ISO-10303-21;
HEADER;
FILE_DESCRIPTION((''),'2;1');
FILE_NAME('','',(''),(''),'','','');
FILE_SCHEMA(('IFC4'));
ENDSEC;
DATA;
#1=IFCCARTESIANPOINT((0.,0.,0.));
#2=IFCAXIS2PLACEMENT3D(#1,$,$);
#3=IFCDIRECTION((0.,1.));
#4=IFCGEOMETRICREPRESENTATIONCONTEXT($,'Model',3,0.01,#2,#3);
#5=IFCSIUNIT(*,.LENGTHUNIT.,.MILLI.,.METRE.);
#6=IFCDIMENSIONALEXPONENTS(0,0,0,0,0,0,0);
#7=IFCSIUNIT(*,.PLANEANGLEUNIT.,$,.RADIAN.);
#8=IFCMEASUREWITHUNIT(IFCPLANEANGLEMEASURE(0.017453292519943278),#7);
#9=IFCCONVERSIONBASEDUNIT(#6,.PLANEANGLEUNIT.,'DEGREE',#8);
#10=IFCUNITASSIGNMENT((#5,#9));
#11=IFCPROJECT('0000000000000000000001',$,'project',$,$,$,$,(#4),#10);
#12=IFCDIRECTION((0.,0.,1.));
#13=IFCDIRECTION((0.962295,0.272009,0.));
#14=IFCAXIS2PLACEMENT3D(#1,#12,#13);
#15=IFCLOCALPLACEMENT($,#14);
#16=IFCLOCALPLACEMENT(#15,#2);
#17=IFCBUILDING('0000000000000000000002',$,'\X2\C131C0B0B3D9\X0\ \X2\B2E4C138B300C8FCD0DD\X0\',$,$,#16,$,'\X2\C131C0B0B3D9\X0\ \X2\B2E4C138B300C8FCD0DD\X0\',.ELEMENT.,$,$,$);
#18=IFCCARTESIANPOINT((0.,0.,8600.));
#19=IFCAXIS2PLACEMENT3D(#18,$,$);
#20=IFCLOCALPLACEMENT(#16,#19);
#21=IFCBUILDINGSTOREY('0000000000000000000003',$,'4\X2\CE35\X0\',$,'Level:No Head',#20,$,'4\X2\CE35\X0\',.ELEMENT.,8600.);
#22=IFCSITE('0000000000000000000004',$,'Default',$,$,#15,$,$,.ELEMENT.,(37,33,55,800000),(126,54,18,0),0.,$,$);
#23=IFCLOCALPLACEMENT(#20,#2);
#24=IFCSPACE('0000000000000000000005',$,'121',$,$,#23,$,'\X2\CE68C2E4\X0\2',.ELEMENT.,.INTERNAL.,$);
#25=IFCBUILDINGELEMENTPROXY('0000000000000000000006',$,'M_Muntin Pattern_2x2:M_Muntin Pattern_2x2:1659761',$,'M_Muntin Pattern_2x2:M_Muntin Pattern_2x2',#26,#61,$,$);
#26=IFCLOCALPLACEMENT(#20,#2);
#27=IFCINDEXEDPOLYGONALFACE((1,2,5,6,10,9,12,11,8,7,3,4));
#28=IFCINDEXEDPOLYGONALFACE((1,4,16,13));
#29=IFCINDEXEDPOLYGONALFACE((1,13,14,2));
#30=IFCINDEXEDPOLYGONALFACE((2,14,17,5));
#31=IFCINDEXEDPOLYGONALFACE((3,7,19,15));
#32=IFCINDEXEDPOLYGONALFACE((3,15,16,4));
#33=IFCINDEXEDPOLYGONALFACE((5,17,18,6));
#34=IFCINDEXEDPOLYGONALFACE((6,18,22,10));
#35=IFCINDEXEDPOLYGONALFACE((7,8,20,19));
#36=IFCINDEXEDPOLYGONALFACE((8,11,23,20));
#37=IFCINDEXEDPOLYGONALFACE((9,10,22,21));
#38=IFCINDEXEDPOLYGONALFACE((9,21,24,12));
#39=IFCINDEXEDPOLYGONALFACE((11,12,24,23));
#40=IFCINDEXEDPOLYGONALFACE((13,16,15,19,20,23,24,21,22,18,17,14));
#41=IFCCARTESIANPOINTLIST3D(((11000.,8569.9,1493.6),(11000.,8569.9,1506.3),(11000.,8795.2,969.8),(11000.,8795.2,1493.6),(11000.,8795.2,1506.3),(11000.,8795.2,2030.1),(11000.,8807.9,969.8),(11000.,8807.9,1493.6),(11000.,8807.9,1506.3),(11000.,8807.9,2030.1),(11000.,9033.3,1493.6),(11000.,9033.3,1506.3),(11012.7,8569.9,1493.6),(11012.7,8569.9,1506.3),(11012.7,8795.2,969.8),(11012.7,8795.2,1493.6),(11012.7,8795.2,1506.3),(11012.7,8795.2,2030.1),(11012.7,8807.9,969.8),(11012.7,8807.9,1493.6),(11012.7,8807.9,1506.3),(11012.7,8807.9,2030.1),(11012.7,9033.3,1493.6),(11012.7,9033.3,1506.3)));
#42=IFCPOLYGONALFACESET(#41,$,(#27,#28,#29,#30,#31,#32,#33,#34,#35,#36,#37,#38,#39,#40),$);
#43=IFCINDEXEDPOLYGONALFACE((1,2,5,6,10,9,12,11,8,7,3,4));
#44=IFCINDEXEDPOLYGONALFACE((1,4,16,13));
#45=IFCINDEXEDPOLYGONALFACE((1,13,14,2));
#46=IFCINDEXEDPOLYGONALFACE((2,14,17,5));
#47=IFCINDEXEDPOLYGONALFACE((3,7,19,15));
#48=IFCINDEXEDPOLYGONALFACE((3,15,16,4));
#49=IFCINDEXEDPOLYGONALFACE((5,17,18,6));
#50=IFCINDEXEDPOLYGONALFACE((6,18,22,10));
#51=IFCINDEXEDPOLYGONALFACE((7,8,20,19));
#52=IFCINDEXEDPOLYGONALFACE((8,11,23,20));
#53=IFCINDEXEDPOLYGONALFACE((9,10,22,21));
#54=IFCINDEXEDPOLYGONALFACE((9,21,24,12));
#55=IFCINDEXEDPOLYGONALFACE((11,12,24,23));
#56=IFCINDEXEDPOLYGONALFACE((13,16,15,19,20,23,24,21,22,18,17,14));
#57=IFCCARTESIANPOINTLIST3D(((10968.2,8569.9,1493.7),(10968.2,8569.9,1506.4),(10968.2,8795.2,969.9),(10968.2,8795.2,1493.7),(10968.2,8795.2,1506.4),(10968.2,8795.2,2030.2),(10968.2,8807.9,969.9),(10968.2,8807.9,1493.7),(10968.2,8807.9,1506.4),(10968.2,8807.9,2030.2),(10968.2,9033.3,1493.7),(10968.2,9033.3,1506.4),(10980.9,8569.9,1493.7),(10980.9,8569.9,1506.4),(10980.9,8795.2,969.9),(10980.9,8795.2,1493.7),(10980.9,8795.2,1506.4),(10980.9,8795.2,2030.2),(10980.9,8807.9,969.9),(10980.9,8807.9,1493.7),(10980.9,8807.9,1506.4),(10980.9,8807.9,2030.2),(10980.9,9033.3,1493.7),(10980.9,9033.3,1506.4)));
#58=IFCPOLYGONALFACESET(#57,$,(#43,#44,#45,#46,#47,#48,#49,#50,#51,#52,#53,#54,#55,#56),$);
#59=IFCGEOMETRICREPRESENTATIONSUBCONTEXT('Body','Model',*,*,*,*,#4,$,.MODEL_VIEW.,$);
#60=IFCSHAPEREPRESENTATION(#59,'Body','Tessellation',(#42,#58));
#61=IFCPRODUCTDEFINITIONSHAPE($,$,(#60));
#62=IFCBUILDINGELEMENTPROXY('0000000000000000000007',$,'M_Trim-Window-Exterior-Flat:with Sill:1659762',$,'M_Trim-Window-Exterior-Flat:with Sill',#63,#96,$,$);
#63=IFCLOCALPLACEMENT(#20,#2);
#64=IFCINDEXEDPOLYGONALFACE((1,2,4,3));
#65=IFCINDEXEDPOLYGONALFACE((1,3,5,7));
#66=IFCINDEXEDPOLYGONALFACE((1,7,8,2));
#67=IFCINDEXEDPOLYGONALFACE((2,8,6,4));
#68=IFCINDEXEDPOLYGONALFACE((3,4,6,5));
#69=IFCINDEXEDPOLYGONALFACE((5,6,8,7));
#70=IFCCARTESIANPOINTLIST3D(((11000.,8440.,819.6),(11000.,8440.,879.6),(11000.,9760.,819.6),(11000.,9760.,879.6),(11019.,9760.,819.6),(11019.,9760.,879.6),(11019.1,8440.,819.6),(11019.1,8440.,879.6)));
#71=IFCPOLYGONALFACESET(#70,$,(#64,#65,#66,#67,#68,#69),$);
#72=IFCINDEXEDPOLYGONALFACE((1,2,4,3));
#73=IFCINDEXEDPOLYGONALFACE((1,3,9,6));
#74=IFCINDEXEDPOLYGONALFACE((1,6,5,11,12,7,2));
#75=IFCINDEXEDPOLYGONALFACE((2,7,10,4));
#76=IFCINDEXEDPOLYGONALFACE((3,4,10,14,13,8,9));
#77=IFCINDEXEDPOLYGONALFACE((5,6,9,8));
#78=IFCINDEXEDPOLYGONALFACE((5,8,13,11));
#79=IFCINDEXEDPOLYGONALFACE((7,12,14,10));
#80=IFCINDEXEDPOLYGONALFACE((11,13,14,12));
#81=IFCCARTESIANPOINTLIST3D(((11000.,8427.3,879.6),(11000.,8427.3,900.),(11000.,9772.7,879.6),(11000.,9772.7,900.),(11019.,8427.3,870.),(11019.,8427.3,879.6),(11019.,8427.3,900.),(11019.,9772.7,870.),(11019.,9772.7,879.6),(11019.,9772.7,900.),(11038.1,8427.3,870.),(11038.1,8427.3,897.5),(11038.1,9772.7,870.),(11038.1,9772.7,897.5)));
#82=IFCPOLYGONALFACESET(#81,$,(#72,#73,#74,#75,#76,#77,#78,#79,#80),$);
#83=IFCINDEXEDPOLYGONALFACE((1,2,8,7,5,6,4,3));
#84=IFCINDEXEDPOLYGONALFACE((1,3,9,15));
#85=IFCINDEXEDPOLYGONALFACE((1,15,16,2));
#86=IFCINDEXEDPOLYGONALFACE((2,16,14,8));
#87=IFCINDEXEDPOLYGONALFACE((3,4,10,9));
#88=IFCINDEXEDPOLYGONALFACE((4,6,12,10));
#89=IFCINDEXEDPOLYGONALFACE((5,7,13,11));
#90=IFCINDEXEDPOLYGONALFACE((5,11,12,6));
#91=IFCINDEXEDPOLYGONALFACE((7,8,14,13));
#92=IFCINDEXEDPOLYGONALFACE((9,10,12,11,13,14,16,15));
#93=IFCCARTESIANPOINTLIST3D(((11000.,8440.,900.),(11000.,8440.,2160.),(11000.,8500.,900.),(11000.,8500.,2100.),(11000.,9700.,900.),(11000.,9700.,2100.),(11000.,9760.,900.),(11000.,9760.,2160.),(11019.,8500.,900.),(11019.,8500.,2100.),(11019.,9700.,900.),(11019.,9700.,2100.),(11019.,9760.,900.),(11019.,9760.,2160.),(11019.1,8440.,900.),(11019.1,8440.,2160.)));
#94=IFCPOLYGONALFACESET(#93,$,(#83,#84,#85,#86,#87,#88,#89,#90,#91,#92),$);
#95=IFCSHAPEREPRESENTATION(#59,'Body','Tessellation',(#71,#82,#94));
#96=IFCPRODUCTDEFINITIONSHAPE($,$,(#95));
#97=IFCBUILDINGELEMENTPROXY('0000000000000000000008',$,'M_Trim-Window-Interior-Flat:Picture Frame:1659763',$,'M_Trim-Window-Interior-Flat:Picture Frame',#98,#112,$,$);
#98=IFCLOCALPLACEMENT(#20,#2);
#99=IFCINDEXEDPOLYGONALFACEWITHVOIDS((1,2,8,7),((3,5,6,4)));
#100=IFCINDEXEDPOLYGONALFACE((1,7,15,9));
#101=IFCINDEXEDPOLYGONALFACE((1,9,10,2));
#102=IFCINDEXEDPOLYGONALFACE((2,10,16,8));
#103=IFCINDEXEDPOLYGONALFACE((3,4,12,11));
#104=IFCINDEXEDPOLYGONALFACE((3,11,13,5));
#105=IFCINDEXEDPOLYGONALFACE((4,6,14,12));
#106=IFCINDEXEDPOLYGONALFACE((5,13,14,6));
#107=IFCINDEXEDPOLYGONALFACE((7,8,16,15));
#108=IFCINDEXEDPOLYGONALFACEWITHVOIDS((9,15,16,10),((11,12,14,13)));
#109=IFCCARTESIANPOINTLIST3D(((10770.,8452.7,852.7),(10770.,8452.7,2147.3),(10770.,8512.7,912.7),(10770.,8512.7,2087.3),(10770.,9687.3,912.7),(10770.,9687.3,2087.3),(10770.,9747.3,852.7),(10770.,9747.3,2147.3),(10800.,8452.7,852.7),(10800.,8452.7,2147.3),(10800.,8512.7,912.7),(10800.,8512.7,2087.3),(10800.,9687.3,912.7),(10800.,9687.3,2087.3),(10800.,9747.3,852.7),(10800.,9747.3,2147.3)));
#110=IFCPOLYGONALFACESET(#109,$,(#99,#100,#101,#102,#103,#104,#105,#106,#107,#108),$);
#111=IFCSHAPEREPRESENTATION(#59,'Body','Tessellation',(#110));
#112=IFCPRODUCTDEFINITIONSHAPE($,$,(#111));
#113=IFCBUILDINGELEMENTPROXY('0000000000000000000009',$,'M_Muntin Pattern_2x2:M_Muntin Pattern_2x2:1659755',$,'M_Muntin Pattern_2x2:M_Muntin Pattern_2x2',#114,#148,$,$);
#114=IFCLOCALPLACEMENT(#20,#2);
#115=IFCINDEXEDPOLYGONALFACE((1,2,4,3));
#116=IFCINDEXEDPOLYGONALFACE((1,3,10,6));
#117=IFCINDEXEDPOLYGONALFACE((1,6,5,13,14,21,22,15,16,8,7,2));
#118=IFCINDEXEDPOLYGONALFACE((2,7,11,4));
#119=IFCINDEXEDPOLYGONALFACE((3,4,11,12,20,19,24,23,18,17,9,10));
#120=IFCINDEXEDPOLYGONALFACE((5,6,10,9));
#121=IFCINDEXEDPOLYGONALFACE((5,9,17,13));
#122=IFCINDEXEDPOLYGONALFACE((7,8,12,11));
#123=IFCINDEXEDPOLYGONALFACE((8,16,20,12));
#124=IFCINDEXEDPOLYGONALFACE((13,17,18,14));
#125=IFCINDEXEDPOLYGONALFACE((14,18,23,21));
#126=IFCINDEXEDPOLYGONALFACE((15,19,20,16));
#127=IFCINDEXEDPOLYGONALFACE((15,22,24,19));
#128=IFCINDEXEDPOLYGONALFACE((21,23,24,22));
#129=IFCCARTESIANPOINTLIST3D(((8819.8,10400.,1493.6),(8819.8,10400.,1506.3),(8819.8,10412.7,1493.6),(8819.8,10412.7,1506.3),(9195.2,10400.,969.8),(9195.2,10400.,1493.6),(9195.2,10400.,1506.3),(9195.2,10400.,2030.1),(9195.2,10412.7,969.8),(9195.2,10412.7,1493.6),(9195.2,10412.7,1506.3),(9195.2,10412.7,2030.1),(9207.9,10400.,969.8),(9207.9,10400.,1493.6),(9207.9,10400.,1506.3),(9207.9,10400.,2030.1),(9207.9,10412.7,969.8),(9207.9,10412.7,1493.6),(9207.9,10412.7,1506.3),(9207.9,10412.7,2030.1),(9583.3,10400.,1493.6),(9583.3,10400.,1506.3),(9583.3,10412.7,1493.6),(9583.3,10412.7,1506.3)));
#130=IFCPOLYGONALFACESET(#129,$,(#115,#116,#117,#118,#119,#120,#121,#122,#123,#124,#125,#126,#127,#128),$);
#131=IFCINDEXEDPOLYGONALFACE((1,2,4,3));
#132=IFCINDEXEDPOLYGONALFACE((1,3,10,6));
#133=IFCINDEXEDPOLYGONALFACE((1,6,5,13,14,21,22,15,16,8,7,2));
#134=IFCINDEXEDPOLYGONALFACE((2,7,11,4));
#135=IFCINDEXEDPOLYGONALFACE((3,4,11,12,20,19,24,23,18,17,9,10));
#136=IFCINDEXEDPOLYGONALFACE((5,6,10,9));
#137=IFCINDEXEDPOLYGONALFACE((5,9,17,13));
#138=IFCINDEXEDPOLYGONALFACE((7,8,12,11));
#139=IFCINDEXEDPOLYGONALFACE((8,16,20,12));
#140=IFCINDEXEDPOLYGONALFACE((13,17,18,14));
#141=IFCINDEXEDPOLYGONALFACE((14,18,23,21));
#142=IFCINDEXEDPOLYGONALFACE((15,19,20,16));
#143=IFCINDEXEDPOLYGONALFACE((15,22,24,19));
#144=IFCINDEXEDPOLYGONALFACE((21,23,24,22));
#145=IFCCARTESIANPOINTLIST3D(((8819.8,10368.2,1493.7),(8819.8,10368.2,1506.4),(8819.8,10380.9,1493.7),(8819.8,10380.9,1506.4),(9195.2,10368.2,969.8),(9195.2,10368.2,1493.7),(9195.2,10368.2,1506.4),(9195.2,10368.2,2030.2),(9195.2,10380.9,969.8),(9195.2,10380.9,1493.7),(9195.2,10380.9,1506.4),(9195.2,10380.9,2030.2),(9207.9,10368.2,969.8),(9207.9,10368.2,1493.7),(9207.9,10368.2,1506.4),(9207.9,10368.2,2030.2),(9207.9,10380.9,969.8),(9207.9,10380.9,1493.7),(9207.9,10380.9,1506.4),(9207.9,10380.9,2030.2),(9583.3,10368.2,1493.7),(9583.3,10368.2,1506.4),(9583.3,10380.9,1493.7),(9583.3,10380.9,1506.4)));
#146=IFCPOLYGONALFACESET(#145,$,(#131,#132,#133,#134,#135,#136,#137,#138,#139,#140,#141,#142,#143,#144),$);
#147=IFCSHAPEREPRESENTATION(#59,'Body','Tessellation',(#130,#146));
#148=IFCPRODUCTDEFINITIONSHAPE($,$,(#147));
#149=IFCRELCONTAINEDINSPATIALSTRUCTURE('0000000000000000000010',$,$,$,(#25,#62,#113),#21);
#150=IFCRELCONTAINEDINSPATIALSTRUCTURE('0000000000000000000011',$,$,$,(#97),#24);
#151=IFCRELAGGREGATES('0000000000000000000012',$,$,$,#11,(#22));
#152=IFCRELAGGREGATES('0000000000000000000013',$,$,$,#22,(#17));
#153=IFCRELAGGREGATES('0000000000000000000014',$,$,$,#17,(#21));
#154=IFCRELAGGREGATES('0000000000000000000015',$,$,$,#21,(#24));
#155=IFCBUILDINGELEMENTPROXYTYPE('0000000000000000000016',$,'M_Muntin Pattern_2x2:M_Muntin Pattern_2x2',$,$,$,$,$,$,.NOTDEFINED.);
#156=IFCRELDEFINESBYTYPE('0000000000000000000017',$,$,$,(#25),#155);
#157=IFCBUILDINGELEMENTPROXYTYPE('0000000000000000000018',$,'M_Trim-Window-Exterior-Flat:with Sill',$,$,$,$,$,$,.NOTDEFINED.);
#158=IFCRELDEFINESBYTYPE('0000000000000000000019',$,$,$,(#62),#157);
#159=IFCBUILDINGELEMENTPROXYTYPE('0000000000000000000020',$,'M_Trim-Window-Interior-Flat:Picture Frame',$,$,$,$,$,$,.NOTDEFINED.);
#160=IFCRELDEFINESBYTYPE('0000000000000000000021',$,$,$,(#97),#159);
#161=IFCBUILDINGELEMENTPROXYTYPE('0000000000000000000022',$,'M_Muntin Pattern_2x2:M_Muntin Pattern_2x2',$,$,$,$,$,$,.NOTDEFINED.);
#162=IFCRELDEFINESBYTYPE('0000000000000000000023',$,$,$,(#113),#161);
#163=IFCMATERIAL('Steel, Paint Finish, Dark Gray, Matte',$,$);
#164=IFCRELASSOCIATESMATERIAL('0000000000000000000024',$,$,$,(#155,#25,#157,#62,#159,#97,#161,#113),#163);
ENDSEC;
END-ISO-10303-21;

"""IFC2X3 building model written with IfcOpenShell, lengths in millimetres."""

from ifc_helpers import new_model, entity, si_unit, converted_unit, direction, frame, frame_2d, origin, place, context, subcontext, project, spatial, polyline, rectangle, outline, extrude, source, transform, mapped, material, type_object, type_shapes, element, save


model = new_model("IFC2X3")

# Units and contexts
model_context = context("Model", 3, precision=0.01, world=origin(), true_north=direction((0.0, 1.0)))
body_context = subcontext(model_context, "Body", "Model", "MODEL_VIEW")
ifc_project = project(units=[si_unit("LENGTHUNIT", "METRE", prefix="MILLI"), converted_unit("PLANEANGLEUNIT", "DEGREE", entity("IfcPlaneAngleMeasure", 0.017453292519943278), si_unit("PLANEANGLEUNIT", "RADIAN"), dimensions=[0, 0, 0, 0, 0, 0, 0])], contexts=[model_context])

# Site, building, storey
site_placement = place(None, frame((0.0, 0.0, 0.0), z_axis=(0.0, 0.0, 1.0), x_axis=(0.962295, 0.272009, 0.0)))
site = spatial("IfcSite", under=ifc_project, at=site_placement, Name="Default", CompositionType="ELEMENT", RefLatitude=(37, 33, 55, 800000), RefLongitude=(126, 54, 18, 0), RefElevation=0.0)
building_placement = place(site_placement, origin())
building = spatial("IfcBuilding", under=site, at=building_placement, Name="성산동 다세대주택", LongName="성산동 다세대주택", CompositionType="ELEMENT")
storey_placement = place(building_placement, frame((0.0, 0.0, 8600.0)))
storey = spatial("IfcBuildingStorey", under=building, at=storey_placement, Name="4층", ObjectType="Level:No Head", LongName="4층", CompositionType="ELEMENT", Elevation=8600.0)

# Shared definitions
space_1_placement = place(storey_placement, origin())
space_1 = spatial("IfcSpace", under=storey, at=space_1_placement, Name="121", LongName="침실2", CompositionType="ELEMENT", InteriorOrExteriorSpace="INTERNAL")

# Building element proxies
ifc_material_1 = material(Name="Steel, Paint Finish, Dark Gray, Matte")
building_element_proxy_type_1 = type_object("IfcBuildingElementProxyType", Name="M_Muntin Pattern_2x2:M_Muntin Pattern_2x2", PredefinedType="NOTDEFINED", material=ifc_material_1)
shared_shape_1 = source(origin(), body_context, "Body", "SweptSolid", [
    extrude(outline(polyline([(6.4, -6.4), (530.1, -6.4), (530.1, 6.3), (6.4, 6.3), (6.4, 231.7), (-6.3, 231.7), (-6.3, 6.3), (-530.2, 6.3), (-530.2, -6.4), (-6.3, -6.4), (-6.3, -231.7), (6.4, -231.7), (6.4, -6.4)])), frame((0.0, -22.2, 530.1), z_axis=(0.0, 1.0, 0.0), x_axis=(0.0, 0.0, 1.0)), (0.0, 0.0, 1.0), 12.7),
    extrude(outline(polyline([(6.4, -6.4), (530.2, -6.4), (530.2, 6.3), (6.4, 6.3), (6.4, 231.7), (-6.3, 231.7), (-6.3, 6.3), (-530.2, 6.3), (-530.2, -6.4), (-6.3, -6.4), (-6.3, -231.7), (6.4, -231.7), (6.4, -6.4)])), frame((0.0, 9.5, 530.2), z_axis=(0.0, 1.0, 0.0), x_axis=(0.0, 0.0, 1.0)), (0.0, 0.0, 1.0), 12.7),
])
type_shapes(building_element_proxy_type_1, [shared_shape_1])
proxy_1_placement = place(storey_placement, frame((10990.5, 8801.6, 969.9), z_axis=(0.0, 0.0, 1.0), x_axis=(0.0, 1.0, 0.0)))
element("IfcBuildingElementProxy", 1, at=proxy_1_placement, inside=storey, type_object=building_element_proxy_type_1, material=ifc_material_1, Name="M_Muntin Pattern_2x2:M_Muntin Pattern_2x2:1659761", ObjectType="M_Muntin Pattern_2x2:M_Muntin Pattern_2x2", context=body_context, shape_type="MappedRepresentation", body=[
    mapped(shared_shape_1, transform((0.0, 0.0, 0.0), scale=1.0)),
])
building_element_proxy_type_2 = type_object("IfcBuildingElementProxyType", Name="M_Trim-Window-Exterior-Flat:with Sill", PredefinedType="NOTDEFINED", material=ifc_material_1)
shared_shape_2 = source(origin(), body_context, "Body", "SweptSolid", [
    extrude(rectangle(XDim=1320.0, YDim=60.0, at=frame_2d((0.0, 0.0), x_axis=(1.0, 0.0))), frame((0.0, -1250.4, 0.0), z_axis=(0.0, 0.0, 1.0), x_axis=(-1.0, 0.0, 0.0)), (0.0, 0.0, 1.0), 19.0),
    extrude(outline(polyline([(-19.0, -15.2), (0.0, -15.2), (0.0, -5.7), (19.0, -5.7), (19.0, 14.8), (0.0, 14.8), (-19.0, 12.3), (-19.0, -15.2)])), frame((-672.7, -1214.8, 19.0), z_axis=(1.0, 0.0, 0.0), x_axis=(0.0, 0.0, -1.0)), (0.0, 0.0, 1.0), 1345.4),
    extrude(outline(polyline([(-645.0, -660.0), (615.0, -660.0), (615.0, -600.0), (-585.0, -600.0), (-585.0, 600.0), (615.0, 600.0), (615.0, 660.0), (-645.0, 660.0), (-645.0, -660.0)])), frame((0.0, -585.0, 0.0), z_axis=(0.0, 0.0, 1.0), x_axis=(0.0, -1.0, 0.0)), (0.0, 0.0, 1.0), 19.0),
])
type_shapes(building_element_proxy_type_2, [shared_shape_2])
proxy_2_placement = place(storey_placement, frame((11000.0, 9100.0, 2100.0), z_axis=(1.0, 0.0, 0.0), x_axis=(0.0, 1.0, 0.0)))
element("IfcBuildingElementProxy", 2, at=proxy_2_placement, inside=storey, type_object=building_element_proxy_type_2, material=ifc_material_1, Name="M_Trim-Window-Exterior-Flat:with Sill:1659762", ObjectType="M_Trim-Window-Exterior-Flat:with Sill", context=body_context, shape_type="MappedRepresentation", body=[
    mapped(shared_shape_2, transform((0.0, 0.0, 0.0), scale=1.0)),
])
building_element_proxy_type_3 = type_object("IfcBuildingElementProxyType", Name="M_Trim-Window-Interior-Flat:Picture Frame", PredefinedType="NOTDEFINED", material=ifc_material_1)
shared_shape_3 = source(origin(), body_context, "Body", "SweptSolid", [
    extrude(outline(polyline([(-647.3, -647.3), (647.3, -647.3), (647.3, 647.3), (-647.3, 647.3), (-647.3, -647.3)]), holes=[polyline([(-587.3, -587.3), (-587.3, 587.3), (587.3, 587.3), (587.3, -587.3), (-587.3, -587.3)])]), frame((0.0, -600.0, 0.0), z_axis=(0.0, 0.0, 1.0), x_axis=(-1.0, 0.0, 0.0)), (0.0, 0.0, 1.0), 30.0),
])
type_shapes(building_element_proxy_type_3, [shared_shape_3])
proxy_3_placement = place(space_1_placement, frame((10800.0, 9100.0, 2100.0), z_axis=(-1.0, 0.0, 0.0), x_axis=(0.0, -1.0, 0.0)))
element("IfcBuildingElementProxy", 3, at=proxy_3_placement, inside=space_1, type_object=building_element_proxy_type_3, material=ifc_material_1, Name="M_Trim-Window-Interior-Flat:Picture Frame:1659763", ObjectType="M_Trim-Window-Interior-Flat:Picture Frame", context=body_context, shape_type="MappedRepresentation", body=[
    mapped(shared_shape_3, transform((0.0, 0.0, 0.0), scale=1.0)),
])
building_element_proxy_type_4 = type_object("IfcBuildingElementProxyType", Name="M_Muntin Pattern_2x2:M_Muntin Pattern_2x2", PredefinedType="NOTDEFINED", material=ifc_material_1)
shared_shape_4 = source(origin(), body_context, "Body", "SweptSolid", [
    extrude(outline(polyline([(6.4, -6.4), (530.1, -6.4), (530.1, 6.3), (6.4, 6.3), (6.4, 381.7), (-6.3, 381.7), (-6.3, 6.3), (-530.2, 6.3), (-530.2, -6.4), (-6.3, -6.4), (-6.3, -381.7), (6.4, -381.7), (6.4, -6.4)])), frame((0.0, 9.5, 530.1), z_axis=(0.0, 1.0, 0.0), x_axis=(0.0, 0.0, 1.0)), (0.0, 0.0, 1.0), 12.7),
    extrude(outline(polyline([(6.4, -6.4), (530.2, -6.4), (530.2, 6.3), (6.4, 6.3), (6.4, 381.7), (-6.3, 381.7), (-6.3, 6.3), (-530.2, 6.3), (-530.2, -6.4), (-6.3, -6.4), (-6.3, -381.7), (6.4, -381.7), (6.4, -6.4)])), frame((0.0, -22.2, 530.2), z_axis=(0.0, 1.0, 0.0), x_axis=(0.0, 0.0, 1.0)), (0.0, 0.0, 1.0), 12.7),
])
type_shapes(building_element_proxy_type_4, [shared_shape_4])
proxy_4_placement = place(storey_placement, frame((9201.6, 10390.5, 969.8)))
element("IfcBuildingElementProxy", 4, at=proxy_4_placement, inside=storey, type_object=building_element_proxy_type_4, material=ifc_material_1, Name="M_Muntin Pattern_2x2:M_Muntin Pattern_2x2:1659755", ObjectType="M_Muntin Pattern_2x2:M_Muntin Pattern_2x2", context=body_context, shape_type="MappedRepresentation", body=[
    mapped(shared_shape_4, transform((0.0, 0.0, 0.0), scale=1.0)),
])

save(model, "model.ifc")
